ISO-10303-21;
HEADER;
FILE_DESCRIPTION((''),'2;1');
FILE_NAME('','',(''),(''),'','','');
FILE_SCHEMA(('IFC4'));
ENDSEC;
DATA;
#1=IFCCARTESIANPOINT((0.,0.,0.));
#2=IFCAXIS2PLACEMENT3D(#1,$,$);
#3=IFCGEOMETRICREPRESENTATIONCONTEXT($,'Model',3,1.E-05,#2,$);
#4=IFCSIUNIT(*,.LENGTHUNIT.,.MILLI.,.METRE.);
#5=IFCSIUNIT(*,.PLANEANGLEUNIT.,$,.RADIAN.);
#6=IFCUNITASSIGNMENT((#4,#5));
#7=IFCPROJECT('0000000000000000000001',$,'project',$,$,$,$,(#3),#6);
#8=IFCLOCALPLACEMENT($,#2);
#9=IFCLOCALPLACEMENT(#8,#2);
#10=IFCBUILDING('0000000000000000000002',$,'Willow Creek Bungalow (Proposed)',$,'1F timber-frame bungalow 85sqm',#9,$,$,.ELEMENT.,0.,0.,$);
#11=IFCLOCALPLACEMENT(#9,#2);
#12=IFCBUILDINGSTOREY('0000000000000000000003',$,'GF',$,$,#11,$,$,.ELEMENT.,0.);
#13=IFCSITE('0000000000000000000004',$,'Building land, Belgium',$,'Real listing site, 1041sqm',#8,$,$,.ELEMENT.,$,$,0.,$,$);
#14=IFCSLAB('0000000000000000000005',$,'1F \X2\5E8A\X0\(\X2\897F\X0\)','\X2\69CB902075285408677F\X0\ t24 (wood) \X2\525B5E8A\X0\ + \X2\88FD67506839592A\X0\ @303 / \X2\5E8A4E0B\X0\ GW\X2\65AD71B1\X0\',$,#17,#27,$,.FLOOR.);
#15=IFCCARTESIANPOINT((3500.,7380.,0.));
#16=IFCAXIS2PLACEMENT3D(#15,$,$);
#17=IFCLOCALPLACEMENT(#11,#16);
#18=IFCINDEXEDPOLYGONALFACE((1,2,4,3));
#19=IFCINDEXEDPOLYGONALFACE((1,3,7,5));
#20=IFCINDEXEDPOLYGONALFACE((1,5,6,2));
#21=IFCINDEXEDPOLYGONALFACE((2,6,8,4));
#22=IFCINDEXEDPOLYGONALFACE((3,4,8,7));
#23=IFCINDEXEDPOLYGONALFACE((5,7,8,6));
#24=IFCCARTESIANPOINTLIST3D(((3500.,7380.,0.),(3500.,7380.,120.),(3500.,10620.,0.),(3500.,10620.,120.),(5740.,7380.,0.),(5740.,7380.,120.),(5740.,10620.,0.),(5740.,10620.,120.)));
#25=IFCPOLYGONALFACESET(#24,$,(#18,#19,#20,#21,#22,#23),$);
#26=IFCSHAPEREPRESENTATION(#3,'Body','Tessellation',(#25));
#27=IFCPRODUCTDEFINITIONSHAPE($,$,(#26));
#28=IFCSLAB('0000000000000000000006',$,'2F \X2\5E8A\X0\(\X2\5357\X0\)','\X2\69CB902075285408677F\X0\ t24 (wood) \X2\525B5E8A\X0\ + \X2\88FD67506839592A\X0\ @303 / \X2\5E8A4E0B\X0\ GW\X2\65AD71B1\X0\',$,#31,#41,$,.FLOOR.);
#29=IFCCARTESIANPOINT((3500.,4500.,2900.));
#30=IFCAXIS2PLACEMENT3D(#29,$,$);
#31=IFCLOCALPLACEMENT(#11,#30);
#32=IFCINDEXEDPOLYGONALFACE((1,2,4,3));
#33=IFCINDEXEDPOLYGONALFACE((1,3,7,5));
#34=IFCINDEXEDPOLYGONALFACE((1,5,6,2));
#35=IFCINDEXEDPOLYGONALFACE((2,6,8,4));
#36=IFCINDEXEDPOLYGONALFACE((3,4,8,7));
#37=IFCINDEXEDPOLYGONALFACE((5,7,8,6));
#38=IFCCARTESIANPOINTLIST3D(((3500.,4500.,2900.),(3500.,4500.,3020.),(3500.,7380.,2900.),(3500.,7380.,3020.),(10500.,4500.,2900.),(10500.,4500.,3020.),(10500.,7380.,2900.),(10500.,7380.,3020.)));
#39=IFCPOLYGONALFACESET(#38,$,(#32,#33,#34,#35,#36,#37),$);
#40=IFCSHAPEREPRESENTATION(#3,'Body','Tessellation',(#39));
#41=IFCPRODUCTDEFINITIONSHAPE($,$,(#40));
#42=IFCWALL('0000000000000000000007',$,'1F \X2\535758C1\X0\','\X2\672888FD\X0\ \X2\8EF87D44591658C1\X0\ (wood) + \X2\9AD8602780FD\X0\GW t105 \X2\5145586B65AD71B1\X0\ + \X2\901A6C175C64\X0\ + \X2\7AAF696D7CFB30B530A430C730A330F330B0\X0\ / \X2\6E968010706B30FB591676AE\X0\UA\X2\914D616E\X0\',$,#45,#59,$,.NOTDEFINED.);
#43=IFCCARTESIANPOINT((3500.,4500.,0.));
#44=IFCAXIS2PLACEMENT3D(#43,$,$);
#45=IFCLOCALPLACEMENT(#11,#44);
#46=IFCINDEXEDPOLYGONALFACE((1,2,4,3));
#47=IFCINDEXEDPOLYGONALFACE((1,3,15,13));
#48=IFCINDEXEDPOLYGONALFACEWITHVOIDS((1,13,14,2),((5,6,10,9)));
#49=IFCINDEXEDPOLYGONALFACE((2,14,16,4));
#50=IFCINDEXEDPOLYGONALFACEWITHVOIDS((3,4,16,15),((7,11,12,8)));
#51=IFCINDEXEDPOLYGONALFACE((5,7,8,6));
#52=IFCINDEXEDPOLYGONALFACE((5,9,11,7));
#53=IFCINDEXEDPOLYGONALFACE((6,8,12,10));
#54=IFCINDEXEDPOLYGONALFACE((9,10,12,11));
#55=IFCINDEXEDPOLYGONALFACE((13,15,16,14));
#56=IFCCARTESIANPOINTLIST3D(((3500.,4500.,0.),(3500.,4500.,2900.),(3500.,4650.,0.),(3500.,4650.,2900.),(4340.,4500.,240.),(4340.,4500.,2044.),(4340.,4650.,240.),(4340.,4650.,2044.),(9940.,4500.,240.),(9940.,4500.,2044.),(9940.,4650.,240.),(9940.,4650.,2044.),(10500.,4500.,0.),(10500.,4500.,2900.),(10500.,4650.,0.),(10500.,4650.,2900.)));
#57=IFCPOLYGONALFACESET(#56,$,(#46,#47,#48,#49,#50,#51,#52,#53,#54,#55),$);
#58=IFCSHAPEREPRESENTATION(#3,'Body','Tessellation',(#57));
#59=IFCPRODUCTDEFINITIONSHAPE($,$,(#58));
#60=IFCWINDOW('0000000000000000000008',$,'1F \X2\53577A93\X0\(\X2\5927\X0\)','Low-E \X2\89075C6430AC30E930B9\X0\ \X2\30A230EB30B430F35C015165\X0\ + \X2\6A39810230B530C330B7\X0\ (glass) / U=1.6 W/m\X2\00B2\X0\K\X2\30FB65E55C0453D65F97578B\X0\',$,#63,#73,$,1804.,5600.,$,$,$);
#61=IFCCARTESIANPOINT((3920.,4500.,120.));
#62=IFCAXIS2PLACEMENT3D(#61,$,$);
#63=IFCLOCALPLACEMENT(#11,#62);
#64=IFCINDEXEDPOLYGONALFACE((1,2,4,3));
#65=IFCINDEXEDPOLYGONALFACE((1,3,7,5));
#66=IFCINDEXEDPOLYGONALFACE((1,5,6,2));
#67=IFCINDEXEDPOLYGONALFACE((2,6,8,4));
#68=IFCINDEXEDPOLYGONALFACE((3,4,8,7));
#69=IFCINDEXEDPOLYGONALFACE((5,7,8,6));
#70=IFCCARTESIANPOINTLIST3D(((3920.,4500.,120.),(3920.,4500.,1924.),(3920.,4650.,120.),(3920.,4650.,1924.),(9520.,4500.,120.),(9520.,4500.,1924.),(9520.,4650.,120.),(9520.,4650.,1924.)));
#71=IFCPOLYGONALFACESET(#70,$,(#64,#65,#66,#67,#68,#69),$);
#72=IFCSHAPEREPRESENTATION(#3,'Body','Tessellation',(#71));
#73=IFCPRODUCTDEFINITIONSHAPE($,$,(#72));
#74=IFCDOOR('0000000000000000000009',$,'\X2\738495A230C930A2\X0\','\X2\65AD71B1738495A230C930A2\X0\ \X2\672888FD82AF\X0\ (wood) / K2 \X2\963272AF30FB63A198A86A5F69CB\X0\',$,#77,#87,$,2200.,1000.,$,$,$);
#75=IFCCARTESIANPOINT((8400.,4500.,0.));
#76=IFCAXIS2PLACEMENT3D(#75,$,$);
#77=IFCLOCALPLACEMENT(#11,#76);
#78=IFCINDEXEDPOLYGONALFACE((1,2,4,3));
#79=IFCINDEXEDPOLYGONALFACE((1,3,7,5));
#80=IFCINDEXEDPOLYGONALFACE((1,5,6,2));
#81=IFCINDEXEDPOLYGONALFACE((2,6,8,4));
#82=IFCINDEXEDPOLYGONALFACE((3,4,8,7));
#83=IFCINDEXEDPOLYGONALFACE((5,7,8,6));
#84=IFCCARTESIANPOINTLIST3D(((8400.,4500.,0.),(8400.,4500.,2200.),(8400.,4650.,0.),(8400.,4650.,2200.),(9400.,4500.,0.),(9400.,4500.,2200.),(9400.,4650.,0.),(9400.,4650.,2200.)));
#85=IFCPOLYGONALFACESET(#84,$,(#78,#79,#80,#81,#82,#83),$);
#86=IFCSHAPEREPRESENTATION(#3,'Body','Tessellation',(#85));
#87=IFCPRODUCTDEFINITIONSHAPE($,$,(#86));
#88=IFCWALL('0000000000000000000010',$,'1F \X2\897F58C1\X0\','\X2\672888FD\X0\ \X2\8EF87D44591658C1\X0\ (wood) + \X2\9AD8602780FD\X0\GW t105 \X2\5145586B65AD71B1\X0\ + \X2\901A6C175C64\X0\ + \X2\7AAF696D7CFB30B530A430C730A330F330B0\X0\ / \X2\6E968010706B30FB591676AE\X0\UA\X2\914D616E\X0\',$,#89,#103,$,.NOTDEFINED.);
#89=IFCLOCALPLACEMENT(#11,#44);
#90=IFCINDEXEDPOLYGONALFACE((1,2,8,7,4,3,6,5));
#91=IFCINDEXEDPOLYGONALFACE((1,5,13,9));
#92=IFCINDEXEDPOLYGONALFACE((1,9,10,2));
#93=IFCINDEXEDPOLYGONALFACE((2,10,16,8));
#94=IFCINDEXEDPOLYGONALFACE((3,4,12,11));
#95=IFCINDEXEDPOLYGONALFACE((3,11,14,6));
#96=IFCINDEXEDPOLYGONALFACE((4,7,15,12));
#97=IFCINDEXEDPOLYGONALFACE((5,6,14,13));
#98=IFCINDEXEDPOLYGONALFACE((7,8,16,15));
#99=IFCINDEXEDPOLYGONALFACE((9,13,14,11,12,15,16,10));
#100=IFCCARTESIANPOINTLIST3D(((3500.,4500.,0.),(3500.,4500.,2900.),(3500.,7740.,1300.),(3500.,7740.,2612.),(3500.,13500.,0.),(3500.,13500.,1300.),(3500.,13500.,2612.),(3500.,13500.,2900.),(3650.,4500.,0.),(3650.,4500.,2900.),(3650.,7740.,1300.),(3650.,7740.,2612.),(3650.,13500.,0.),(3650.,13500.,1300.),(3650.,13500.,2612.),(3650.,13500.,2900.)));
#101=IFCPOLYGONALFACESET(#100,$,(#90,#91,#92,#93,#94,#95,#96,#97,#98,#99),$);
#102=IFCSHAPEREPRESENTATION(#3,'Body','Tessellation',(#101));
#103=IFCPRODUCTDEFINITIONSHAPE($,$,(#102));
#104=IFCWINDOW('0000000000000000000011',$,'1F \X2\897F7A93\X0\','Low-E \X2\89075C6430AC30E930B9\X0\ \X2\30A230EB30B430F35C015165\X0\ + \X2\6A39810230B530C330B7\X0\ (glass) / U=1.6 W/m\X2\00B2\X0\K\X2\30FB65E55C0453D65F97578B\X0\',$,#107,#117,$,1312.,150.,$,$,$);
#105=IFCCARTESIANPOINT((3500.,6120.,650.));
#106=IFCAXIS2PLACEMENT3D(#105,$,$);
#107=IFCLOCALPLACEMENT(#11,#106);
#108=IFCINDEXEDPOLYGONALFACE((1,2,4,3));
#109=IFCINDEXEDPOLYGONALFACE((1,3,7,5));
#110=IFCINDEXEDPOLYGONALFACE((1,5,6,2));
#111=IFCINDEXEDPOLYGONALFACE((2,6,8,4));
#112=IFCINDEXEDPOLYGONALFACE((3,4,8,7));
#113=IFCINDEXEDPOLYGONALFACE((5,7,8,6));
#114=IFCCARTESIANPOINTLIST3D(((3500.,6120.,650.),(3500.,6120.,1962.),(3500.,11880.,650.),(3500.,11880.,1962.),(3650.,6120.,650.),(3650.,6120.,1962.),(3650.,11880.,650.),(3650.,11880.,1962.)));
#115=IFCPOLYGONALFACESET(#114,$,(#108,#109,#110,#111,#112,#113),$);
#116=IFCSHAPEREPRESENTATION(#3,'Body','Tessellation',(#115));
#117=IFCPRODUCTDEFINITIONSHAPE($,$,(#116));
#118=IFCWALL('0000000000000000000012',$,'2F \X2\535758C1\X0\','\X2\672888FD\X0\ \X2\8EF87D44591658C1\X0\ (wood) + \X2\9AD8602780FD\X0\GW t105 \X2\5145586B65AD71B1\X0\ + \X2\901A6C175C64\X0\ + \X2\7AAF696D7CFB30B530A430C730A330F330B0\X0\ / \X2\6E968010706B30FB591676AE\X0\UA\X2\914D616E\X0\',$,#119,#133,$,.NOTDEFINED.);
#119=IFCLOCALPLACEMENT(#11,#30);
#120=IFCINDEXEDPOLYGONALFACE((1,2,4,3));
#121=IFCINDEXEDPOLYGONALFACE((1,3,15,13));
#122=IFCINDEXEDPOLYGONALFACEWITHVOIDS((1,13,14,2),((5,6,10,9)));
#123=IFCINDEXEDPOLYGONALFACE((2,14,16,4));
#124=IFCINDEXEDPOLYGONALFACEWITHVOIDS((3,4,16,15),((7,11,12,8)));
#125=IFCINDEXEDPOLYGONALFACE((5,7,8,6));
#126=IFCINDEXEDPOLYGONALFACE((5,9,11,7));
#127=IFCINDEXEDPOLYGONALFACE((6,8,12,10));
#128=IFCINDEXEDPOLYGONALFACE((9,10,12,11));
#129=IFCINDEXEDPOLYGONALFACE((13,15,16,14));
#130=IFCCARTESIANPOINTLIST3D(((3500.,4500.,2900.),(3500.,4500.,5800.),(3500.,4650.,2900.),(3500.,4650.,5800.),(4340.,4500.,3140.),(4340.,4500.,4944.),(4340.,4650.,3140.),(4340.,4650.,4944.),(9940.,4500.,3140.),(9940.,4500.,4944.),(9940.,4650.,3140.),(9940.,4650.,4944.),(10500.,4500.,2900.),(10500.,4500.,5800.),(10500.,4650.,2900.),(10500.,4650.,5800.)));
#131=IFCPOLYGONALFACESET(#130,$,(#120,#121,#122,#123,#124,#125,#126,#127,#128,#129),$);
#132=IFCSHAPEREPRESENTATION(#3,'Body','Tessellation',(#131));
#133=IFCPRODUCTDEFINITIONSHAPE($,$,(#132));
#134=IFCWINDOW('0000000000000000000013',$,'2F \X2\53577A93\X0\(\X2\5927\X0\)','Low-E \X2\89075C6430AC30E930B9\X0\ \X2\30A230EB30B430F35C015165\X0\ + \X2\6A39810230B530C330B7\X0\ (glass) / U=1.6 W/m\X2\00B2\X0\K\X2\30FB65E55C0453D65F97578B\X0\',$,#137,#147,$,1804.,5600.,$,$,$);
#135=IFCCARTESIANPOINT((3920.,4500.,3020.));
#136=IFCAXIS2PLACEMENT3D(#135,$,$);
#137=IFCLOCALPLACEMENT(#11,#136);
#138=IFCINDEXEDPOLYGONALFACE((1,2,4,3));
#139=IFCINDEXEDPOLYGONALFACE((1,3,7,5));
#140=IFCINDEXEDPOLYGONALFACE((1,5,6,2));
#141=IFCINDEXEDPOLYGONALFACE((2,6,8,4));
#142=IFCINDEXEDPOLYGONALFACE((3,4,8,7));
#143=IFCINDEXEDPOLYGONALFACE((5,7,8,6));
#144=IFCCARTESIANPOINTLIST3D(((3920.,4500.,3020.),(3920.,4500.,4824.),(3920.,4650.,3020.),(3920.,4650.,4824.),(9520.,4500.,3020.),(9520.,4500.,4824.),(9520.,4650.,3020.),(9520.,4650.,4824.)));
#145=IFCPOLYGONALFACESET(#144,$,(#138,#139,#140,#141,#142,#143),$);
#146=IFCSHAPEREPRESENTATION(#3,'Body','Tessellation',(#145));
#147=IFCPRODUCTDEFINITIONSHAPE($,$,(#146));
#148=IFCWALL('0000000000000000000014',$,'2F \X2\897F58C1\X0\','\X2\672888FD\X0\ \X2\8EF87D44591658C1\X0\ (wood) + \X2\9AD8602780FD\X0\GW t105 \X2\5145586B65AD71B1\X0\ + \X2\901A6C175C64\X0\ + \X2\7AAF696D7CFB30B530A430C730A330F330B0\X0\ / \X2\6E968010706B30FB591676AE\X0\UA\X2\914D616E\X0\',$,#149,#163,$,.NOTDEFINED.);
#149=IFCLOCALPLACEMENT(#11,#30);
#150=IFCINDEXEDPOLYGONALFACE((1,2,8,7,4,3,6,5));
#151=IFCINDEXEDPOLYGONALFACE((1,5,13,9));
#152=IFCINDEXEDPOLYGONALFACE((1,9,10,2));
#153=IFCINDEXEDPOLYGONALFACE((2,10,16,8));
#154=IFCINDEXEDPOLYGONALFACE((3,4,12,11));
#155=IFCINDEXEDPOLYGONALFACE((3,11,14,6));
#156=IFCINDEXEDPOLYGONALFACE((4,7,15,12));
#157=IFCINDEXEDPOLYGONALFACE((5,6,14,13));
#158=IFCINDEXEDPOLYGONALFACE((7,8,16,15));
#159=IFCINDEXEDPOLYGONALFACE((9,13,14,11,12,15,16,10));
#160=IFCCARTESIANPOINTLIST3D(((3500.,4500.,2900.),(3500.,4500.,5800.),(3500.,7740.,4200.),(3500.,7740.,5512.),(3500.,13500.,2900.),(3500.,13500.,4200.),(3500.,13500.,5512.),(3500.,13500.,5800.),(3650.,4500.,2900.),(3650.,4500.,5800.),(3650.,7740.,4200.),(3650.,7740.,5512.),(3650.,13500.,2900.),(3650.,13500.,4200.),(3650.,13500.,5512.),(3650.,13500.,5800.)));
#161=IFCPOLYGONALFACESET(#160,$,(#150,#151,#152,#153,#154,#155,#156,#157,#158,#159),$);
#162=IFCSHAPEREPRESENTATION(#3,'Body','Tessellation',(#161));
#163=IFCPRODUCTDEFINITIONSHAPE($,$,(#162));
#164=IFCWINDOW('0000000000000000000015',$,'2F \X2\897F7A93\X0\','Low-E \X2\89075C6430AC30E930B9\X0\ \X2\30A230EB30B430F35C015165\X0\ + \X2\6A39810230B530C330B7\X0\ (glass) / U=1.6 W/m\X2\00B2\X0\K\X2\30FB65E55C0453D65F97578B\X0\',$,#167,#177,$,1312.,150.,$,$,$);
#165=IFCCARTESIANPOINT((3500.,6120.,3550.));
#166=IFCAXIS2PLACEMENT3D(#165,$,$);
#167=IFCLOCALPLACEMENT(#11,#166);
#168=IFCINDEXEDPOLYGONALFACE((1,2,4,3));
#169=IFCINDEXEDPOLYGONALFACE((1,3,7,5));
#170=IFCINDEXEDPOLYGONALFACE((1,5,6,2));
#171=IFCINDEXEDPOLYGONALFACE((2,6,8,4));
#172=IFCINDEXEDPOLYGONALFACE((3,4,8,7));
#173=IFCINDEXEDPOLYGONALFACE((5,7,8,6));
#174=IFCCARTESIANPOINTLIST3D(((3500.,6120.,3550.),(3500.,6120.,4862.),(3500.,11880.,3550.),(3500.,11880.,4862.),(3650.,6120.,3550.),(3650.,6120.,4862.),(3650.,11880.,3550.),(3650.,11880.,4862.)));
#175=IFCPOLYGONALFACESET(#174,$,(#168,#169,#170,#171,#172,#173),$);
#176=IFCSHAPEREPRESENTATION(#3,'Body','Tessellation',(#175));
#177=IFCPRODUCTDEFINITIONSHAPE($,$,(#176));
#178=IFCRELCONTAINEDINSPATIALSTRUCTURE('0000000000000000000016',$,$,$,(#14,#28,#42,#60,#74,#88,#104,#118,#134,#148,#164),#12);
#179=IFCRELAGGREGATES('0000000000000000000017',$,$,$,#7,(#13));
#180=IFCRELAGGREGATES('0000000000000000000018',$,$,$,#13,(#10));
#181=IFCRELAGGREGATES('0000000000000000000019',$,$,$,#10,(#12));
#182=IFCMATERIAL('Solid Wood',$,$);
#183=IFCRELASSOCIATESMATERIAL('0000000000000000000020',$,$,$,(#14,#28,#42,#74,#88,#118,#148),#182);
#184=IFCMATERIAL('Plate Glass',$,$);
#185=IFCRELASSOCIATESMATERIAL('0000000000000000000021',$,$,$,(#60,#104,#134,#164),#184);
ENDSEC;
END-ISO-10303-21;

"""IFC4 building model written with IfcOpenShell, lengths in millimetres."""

from ifc_helpers import new_model, si_unit, frame, frame_2d, origin, place, context, project, spatial, rectangle, extrude, material, element, fill, save


model = new_model("IFC4")

# Units and contexts
model_context = context("Model", 3, precision=1e-05, world=origin())
ifc_project = project(units=[si_unit("LENGTHUNIT", "METRE", prefix="MILLI"), si_unit("PLANEANGLEUNIT", "RADIAN")], contexts=[model_context])

# Site, building, storey
site_placement = place(None, origin())
site = spatial("IfcSite", under=ifc_project, at=site_placement, Name="Building land, Belgium", ObjectType="Real listing site, 1041sqm", CompositionType="ELEMENT", RefElevation=0.0)
building_placement = place(site_placement, origin())
building = spatial("IfcBuilding", under=site, at=building_placement, Name="Willow Creek Bungalow (Proposed)", ObjectType="1F timber-frame bungalow 85sqm", CompositionType="ELEMENT", ElevationOfRefHeight=0.0, ElevationOfTerrain=0.0)
storey_placement = place(building_placement, origin())
storey = spatial("IfcBuildingStorey", under=building, at=storey_placement, Name="GF", CompositionType="ELEMENT", Elevation=0.0)

# Slabs
ifc_material_1 = material(Name="Solid Wood")
slab_1_placement = place(storey_placement, frame((3500.0, 7380.0, 0.0)))
element("IfcSlab", 1, at=slab_1_placement, inside=storey, material=ifc_material_1, Name="1F 床(西)", Description="構造用合板 t24 (wood) 剛床 + 製材根太 @303 / 床下 GW断熱", PredefinedType="FLOOR", context=model_context, shape_type="SweptSolid", body=[
    extrude(rectangle(XDim=2240.0, YDim=3240.0, at=frame_2d((1120.0, 1620.0))), frame((3500.0, 7380.0, 0.0)), (0.0, 0.0, 1.0), 120.0),
])
slab_2_placement = place(storey_placement, frame((3500.0, 4500.0, 2900.0)))
element("IfcSlab", 2, at=slab_2_placement, inside=storey, material=ifc_material_1, Name="2F 床(南)", Description="構造用合板 t24 (wood) 剛床 + 製材根太 @303 / 床下 GW断熱", PredefinedType="FLOOR", context=model_context, shape_type="SweptSolid", body=[
    extrude(rectangle(XDim=7000.0, YDim=2880.0, at=frame_2d((3500.0, 1440.0))), frame((3500.0, 4500.0, 2900.0)), (0.0, 0.0, 1.0), 120.0),
])

# Wall, openings, window, door
wall_1_placement = place(storey_placement, frame((3500.0, 4500.0, 0.0)))
wall_1 = element("IfcWall", 3, at=wall_1_placement, inside=storey, material=ifc_material_1, Name="1F 南壁", Description="木製 軸組外壁 (wood) + 高性能GW t105 充填断熱 + 通気層 + 窯業系サイディング / 準耐火・外皮UA配慮", PredefinedType="NOTDEFINED", context=model_context, shape_type="SweptSolid", body=[
    extrude(rectangle(XDim=7000.0, YDim=150.0, at=frame_2d((3500.0, 75.0))), frame((3500.0, 4500.0, 0.0)), (0.0, 0.0, 1.0), 2900.0),
])
opening_1_placement = place(storey_placement, frame((3920.0, 4500.0, 120.0)))
opening_1 = element("IfcOpeningElement", 4, at=opening_1_placement, cuts=wall_1, PredefinedType="NOTDEFINED", context=model_context, shape_type="SweptSolid", body=[
    extrude(rectangle(XDim=5600.0, YDim=150.0, at=frame_2d((2800.0, 75.0))), frame((3920.0, 4500.0, 120.0)), (0.0, 0.0, 1.0), 1804.0),
])
opening_2_placement = place(storey_placement, frame((8400.0, 4500.0, 0.0)))
opening_2 = element("IfcOpeningElement", 5, at=opening_2_placement, cuts=wall_1, PredefinedType="NOTDEFINED", context=model_context, shape_type="SweptSolid", body=[
    extrude(rectangle(XDim=1000.0, YDim=150.0, at=frame_2d((500.0, 75.0))), frame((8400.0, 4500.0, 0.0)), (0.0, 0.0, 1.0), 2200.0),
])
ifc_material_2 = material(Name="Plate Glass")
window_1_placement = place(storey_placement, frame((3920.0, 4500.0, 120.0)))
window_1 = element("IfcWindow", 6, at=window_1_placement, inside=storey, material=ifc_material_2, Name="1F 南窓(大)", Description="Low-E 複層ガラス アルゴン封入 + 樹脂サッシ (glass) / U=1.6 W/m²K・日射取得型", OverallHeight=1804.0, OverallWidth=5600.0, context=model_context, shape_type="SweptSolid", body=[
    extrude(rectangle(XDim=5600.0, YDim=150.0, at=frame_2d((2800.0, 75.0))), frame((3920.0, 4500.0, 120.0)), (0.0, 0.0, 1.0), 1804.0),
])
fill(opening_1, window_1)
door_placement = place(storey_placement, frame((8400.0, 4500.0, 0.0)))
door = element("IfcDoor", 7, at=door_placement, inside=storey, material=ifc_material_1, Name="玄関ドア", Description="断熱玄関ドア 木製芯 (wood) / K2 防犯・採風機構", OverallHeight=2200.0, OverallWidth=1000.0, context=model_context, shape_type="SweptSolid", body=[
    extrude(rectangle(XDim=1000.0, YDim=150.0, at=frame_2d((500.0, 75.0))), frame((8400.0, 4500.0, 0.0)), (0.0, 0.0, 1.0), 2200.0),
])
fill(opening_2, door)

# Walls, openings, windows
wall_2_placement = place(storey_placement, frame((3500.0, 4500.0, 0.0)))
wall_2 = element("IfcWall", 8, at=wall_2_placement, inside=storey, material=ifc_material_1, Name="1F 西壁", Description="木製 軸組外壁 (wood) + 高性能GW t105 充填断熱 + 通気層 + 窯業系サイディング / 準耐火・外皮UA配慮", PredefinedType="NOTDEFINED", context=model_context, shape_type="SweptSolid", body=[
    extrude(rectangle(XDim=150.0, YDim=9000.0, at=frame_2d((75.0, 4500.0))), frame((3500.0, 4500.0, 0.0)), (0.0, 0.0, 1.0), 2900.0),
])
opening_3_placement = place(storey_placement, frame((3500.0, 6120.0, 650.0)))
opening_3 = element("IfcOpeningElement", 9, at=opening_3_placement, cuts=wall_2, PredefinedType="NOTDEFINED", context=model_context, shape_type="SweptSolid", body=[
    extrude(rectangle(XDim=150.0, YDim=5760.0, at=frame_2d((75.0, 2880.0))), frame((3500.0, 6120.0, 650.0)), (0.0, 0.0, 1.0), 1312.0),
])
window_2_placement = place(storey_placement, frame((3500.0, 6120.0, 650.0)))
window_2 = element("IfcWindow", 10, at=window_2_placement, inside=storey, material=ifc_material_2, Name="1F 西窓", Description="Low-E 複層ガラス アルゴン封入 + 樹脂サッシ (glass) / U=1.6 W/m²K・日射取得型", OverallHeight=1312.0, OverallWidth=150.0, context=model_context, shape_type="SweptSolid", body=[
    extrude(rectangle(XDim=150.0, YDim=5760.0, at=frame_2d((75.0, 2880.0))), frame((3500.0, 6120.0, 650.0)), (0.0, 0.0, 1.0), 1312.0),
])
fill(opening_3, window_2)
wall_3_placement = place(storey_placement, frame((3500.0, 4500.0, 2900.0)))
wall_3 = element("IfcWall", 11, at=wall_3_placement, inside=storey, material=ifc_material_1, Name="2F 南壁", Description="木製 軸組外壁 (wood) + 高性能GW t105 充填断熱 + 通気層 + 窯業系サイディング / 準耐火・外皮UA配慮", PredefinedType="NOTDEFINED", context=model_context, shape_type="SweptSolid", body=[
    extrude(rectangle(XDim=7000.0, YDim=150.0, at=frame_2d((3500.0, 75.0))), frame((3500.0, 4500.0, 2900.0)), (0.0, 0.0, 1.0), 2900.0),
])
opening_4_placement = place(storey_placement, frame((3920.0, 4500.0, 3020.0)))
opening_4 = element("IfcOpeningElement", 12, at=opening_4_placement, cuts=wall_3, PredefinedType="NOTDEFINED", context=model_context, shape_type="SweptSolid", body=[
    extrude(rectangle(XDim=5600.0, YDim=150.0, at=frame_2d((2800.0, 75.0))), frame((3920.0, 4500.0, 3020.0)), (0.0, 0.0, 1.0), 1804.0),
])
window_3_placement = place(storey_placement, frame((3920.0, 4500.0, 3020.0)))
window_3 = element("IfcWindow", 13, at=window_3_placement, inside=storey, material=ifc_material_2, Name="2F 南窓(大)", Description="Low-E 複層ガラス アルゴン封入 + 樹脂サッシ (glass) / U=1.6 W/m²K・日射取得型", OverallHeight=1804.0, OverallWidth=5600.0, context=model_context, shape_type="SweptSolid", body=[
    extrude(rectangle(XDim=5600.0, YDim=150.0, at=frame_2d((2800.0, 75.0))), frame((3920.0, 4500.0, 3020.0)), (0.0, 0.0, 1.0), 1804.0),
])
fill(opening_4, window_3)
wall_4_placement = place(storey_placement, frame((3500.0, 4500.0, 2900.0)))
wall_4 = element("IfcWall", 14, at=wall_4_placement, inside=storey, material=ifc_material_1, Name="2F 西壁", Description="木製 軸組外壁 (wood) + 高性能GW t105 充填断熱 + 通気層 + 窯業系サイディング / 準耐火・外皮UA配慮", PredefinedType="NOTDEFINED", context=model_context, shape_type="SweptSolid", body=[
    extrude(rectangle(XDim=150.0, YDim=9000.0, at=frame_2d((75.0, 4500.0))), frame((3500.0, 4500.0, 2900.0)), (0.0, 0.0, 1.0), 2900.0),
])
opening_5_placement = place(storey_placement, frame((3500.0, 6120.0, 3550.0)))
opening_5 = element("IfcOpeningElement", 15, at=opening_5_placement, cuts=wall_4, PredefinedType="NOTDEFINED", context=model_context, shape_type="SweptSolid", body=[
    extrude(rectangle(XDim=150.0, YDim=5760.0, at=frame_2d((75.0, 2880.0))), frame((3500.0, 6120.0, 3550.0)), (0.0, 0.0, 1.0), 1312.0),
])
window_4_placement = place(storey_placement, frame((3500.0, 6120.0, 3550.0)))
window_4 = element("IfcWindow", 16, at=window_4_placement, inside=storey, material=ifc_material_2, Name="2F 西窓", Description="Low-E 複層ガラス アルゴン封入 + 樹脂サッシ (glass) / U=1.6 W/m²K・日射取得型", OverallHeight=1312.0, OverallWidth=150.0, context=model_context, shape_type="SweptSolid", body=[
    extrude(rectangle(XDim=150.0, YDim=5760.0, at=frame_2d((75.0, 2880.0))), frame((3500.0, 6120.0, 3550.0)), (0.0, 0.0, 1.0), 1312.0),
])
fill(opening_5, window_4)

save(model, "model.ifc")
